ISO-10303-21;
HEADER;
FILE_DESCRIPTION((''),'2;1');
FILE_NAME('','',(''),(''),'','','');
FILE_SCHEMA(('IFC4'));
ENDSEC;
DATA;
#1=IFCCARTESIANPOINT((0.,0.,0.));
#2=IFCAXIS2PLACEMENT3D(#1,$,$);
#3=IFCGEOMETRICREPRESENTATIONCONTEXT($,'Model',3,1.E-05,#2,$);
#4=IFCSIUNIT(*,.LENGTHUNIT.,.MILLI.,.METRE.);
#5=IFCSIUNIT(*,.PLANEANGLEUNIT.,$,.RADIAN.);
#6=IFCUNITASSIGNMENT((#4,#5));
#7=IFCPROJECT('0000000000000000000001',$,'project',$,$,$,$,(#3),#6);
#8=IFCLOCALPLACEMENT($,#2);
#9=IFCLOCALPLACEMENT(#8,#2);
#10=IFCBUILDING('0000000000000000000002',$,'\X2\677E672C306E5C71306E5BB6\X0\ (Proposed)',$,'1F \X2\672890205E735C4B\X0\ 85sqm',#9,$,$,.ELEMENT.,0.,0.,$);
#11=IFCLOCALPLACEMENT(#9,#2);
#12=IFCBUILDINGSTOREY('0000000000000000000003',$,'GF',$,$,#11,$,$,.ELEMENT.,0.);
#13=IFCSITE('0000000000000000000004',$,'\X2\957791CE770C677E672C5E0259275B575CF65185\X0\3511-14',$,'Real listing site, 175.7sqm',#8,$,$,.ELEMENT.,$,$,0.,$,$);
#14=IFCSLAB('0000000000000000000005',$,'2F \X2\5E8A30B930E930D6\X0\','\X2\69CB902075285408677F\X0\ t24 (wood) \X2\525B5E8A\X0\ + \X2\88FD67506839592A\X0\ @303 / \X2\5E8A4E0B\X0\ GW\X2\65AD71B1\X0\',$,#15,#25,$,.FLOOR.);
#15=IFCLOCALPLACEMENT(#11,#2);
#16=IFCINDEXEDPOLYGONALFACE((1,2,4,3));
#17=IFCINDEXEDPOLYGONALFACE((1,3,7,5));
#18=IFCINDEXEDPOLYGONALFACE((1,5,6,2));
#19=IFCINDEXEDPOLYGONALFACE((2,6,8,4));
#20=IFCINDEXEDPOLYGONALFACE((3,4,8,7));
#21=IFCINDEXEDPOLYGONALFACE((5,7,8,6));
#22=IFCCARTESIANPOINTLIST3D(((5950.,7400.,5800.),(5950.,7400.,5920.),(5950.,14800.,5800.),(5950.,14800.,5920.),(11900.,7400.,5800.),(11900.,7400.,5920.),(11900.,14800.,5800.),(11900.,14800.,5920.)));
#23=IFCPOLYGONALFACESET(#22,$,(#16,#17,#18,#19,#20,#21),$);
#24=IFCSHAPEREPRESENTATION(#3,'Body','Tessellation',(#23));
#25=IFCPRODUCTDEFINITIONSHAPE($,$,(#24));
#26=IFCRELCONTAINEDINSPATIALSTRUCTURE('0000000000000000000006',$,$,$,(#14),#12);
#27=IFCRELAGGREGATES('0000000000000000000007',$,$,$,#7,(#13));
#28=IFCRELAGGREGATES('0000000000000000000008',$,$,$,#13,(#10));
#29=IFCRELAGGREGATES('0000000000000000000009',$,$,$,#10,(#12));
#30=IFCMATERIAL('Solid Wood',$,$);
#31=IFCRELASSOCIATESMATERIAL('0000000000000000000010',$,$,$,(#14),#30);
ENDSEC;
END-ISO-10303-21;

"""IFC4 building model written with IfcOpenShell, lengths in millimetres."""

from ifc_helpers import new_model, si_unit, frame, frame_2d, origin, place, context, project, spatial, rectangle, extrude, material, element, save


model = new_model("IFC4")

# Units and contexts
model_context = context("Model", 3, precision=1e-05, world=origin())
ifc_project = project(units=[si_unit("LENGTHUNIT", "METRE", prefix="MILLI"), si_unit("PLANEANGLEUNIT", "RADIAN")], contexts=[model_context])

# Site, building, storey
site_placement = place(None, origin())
site = spatial("IfcSite", under=ifc_project, at=site_placement, Name="長野県松本市大字島内3511-14", ObjectType="Real listing site, 175.7sqm", CompositionType="ELEMENT", RefElevation=0.0)
building_placement = place(site_placement, origin())
building = spatial("IfcBuilding", under=site, at=building_placement, Name="松本の山の家 (Proposed)", ObjectType="1F 木造平屋 85sqm", CompositionType="ELEMENT", ElevationOfRefHeight=0.0, ElevationOfTerrain=0.0)
storey_placement = place(building_placement, origin())
storey = spatial("IfcBuildingStorey", under=building, at=storey_placement, Name="GF", CompositionType="ELEMENT", Elevation=0.0)

# Slab
ifc_material_1 = material(Name="Solid Wood")
slab_placement = place(storey_placement, frame((2975.0, 3700.0, 2900.0)))
element("IfcSlab", 1, at=slab_placement, inside=storey, material=ifc_material_1, Name="2F 床スラブ", Description="構造用合板 t24 (wood) 剛床 + 製材根太 @303 / 床下 GW断熱", PredefinedType="FLOOR", context=model_context, shape_type="SweptSolid", body=[
    extrude(rectangle(XDim=5950.0, YDim=7400.0, at=frame_2d((2975.0, 3700.0))), frame((2975.0, 3700.0, 2900.0)), (0.0, 0.0, 1.0), 120.0),
])

save(model, "model.ifc")
